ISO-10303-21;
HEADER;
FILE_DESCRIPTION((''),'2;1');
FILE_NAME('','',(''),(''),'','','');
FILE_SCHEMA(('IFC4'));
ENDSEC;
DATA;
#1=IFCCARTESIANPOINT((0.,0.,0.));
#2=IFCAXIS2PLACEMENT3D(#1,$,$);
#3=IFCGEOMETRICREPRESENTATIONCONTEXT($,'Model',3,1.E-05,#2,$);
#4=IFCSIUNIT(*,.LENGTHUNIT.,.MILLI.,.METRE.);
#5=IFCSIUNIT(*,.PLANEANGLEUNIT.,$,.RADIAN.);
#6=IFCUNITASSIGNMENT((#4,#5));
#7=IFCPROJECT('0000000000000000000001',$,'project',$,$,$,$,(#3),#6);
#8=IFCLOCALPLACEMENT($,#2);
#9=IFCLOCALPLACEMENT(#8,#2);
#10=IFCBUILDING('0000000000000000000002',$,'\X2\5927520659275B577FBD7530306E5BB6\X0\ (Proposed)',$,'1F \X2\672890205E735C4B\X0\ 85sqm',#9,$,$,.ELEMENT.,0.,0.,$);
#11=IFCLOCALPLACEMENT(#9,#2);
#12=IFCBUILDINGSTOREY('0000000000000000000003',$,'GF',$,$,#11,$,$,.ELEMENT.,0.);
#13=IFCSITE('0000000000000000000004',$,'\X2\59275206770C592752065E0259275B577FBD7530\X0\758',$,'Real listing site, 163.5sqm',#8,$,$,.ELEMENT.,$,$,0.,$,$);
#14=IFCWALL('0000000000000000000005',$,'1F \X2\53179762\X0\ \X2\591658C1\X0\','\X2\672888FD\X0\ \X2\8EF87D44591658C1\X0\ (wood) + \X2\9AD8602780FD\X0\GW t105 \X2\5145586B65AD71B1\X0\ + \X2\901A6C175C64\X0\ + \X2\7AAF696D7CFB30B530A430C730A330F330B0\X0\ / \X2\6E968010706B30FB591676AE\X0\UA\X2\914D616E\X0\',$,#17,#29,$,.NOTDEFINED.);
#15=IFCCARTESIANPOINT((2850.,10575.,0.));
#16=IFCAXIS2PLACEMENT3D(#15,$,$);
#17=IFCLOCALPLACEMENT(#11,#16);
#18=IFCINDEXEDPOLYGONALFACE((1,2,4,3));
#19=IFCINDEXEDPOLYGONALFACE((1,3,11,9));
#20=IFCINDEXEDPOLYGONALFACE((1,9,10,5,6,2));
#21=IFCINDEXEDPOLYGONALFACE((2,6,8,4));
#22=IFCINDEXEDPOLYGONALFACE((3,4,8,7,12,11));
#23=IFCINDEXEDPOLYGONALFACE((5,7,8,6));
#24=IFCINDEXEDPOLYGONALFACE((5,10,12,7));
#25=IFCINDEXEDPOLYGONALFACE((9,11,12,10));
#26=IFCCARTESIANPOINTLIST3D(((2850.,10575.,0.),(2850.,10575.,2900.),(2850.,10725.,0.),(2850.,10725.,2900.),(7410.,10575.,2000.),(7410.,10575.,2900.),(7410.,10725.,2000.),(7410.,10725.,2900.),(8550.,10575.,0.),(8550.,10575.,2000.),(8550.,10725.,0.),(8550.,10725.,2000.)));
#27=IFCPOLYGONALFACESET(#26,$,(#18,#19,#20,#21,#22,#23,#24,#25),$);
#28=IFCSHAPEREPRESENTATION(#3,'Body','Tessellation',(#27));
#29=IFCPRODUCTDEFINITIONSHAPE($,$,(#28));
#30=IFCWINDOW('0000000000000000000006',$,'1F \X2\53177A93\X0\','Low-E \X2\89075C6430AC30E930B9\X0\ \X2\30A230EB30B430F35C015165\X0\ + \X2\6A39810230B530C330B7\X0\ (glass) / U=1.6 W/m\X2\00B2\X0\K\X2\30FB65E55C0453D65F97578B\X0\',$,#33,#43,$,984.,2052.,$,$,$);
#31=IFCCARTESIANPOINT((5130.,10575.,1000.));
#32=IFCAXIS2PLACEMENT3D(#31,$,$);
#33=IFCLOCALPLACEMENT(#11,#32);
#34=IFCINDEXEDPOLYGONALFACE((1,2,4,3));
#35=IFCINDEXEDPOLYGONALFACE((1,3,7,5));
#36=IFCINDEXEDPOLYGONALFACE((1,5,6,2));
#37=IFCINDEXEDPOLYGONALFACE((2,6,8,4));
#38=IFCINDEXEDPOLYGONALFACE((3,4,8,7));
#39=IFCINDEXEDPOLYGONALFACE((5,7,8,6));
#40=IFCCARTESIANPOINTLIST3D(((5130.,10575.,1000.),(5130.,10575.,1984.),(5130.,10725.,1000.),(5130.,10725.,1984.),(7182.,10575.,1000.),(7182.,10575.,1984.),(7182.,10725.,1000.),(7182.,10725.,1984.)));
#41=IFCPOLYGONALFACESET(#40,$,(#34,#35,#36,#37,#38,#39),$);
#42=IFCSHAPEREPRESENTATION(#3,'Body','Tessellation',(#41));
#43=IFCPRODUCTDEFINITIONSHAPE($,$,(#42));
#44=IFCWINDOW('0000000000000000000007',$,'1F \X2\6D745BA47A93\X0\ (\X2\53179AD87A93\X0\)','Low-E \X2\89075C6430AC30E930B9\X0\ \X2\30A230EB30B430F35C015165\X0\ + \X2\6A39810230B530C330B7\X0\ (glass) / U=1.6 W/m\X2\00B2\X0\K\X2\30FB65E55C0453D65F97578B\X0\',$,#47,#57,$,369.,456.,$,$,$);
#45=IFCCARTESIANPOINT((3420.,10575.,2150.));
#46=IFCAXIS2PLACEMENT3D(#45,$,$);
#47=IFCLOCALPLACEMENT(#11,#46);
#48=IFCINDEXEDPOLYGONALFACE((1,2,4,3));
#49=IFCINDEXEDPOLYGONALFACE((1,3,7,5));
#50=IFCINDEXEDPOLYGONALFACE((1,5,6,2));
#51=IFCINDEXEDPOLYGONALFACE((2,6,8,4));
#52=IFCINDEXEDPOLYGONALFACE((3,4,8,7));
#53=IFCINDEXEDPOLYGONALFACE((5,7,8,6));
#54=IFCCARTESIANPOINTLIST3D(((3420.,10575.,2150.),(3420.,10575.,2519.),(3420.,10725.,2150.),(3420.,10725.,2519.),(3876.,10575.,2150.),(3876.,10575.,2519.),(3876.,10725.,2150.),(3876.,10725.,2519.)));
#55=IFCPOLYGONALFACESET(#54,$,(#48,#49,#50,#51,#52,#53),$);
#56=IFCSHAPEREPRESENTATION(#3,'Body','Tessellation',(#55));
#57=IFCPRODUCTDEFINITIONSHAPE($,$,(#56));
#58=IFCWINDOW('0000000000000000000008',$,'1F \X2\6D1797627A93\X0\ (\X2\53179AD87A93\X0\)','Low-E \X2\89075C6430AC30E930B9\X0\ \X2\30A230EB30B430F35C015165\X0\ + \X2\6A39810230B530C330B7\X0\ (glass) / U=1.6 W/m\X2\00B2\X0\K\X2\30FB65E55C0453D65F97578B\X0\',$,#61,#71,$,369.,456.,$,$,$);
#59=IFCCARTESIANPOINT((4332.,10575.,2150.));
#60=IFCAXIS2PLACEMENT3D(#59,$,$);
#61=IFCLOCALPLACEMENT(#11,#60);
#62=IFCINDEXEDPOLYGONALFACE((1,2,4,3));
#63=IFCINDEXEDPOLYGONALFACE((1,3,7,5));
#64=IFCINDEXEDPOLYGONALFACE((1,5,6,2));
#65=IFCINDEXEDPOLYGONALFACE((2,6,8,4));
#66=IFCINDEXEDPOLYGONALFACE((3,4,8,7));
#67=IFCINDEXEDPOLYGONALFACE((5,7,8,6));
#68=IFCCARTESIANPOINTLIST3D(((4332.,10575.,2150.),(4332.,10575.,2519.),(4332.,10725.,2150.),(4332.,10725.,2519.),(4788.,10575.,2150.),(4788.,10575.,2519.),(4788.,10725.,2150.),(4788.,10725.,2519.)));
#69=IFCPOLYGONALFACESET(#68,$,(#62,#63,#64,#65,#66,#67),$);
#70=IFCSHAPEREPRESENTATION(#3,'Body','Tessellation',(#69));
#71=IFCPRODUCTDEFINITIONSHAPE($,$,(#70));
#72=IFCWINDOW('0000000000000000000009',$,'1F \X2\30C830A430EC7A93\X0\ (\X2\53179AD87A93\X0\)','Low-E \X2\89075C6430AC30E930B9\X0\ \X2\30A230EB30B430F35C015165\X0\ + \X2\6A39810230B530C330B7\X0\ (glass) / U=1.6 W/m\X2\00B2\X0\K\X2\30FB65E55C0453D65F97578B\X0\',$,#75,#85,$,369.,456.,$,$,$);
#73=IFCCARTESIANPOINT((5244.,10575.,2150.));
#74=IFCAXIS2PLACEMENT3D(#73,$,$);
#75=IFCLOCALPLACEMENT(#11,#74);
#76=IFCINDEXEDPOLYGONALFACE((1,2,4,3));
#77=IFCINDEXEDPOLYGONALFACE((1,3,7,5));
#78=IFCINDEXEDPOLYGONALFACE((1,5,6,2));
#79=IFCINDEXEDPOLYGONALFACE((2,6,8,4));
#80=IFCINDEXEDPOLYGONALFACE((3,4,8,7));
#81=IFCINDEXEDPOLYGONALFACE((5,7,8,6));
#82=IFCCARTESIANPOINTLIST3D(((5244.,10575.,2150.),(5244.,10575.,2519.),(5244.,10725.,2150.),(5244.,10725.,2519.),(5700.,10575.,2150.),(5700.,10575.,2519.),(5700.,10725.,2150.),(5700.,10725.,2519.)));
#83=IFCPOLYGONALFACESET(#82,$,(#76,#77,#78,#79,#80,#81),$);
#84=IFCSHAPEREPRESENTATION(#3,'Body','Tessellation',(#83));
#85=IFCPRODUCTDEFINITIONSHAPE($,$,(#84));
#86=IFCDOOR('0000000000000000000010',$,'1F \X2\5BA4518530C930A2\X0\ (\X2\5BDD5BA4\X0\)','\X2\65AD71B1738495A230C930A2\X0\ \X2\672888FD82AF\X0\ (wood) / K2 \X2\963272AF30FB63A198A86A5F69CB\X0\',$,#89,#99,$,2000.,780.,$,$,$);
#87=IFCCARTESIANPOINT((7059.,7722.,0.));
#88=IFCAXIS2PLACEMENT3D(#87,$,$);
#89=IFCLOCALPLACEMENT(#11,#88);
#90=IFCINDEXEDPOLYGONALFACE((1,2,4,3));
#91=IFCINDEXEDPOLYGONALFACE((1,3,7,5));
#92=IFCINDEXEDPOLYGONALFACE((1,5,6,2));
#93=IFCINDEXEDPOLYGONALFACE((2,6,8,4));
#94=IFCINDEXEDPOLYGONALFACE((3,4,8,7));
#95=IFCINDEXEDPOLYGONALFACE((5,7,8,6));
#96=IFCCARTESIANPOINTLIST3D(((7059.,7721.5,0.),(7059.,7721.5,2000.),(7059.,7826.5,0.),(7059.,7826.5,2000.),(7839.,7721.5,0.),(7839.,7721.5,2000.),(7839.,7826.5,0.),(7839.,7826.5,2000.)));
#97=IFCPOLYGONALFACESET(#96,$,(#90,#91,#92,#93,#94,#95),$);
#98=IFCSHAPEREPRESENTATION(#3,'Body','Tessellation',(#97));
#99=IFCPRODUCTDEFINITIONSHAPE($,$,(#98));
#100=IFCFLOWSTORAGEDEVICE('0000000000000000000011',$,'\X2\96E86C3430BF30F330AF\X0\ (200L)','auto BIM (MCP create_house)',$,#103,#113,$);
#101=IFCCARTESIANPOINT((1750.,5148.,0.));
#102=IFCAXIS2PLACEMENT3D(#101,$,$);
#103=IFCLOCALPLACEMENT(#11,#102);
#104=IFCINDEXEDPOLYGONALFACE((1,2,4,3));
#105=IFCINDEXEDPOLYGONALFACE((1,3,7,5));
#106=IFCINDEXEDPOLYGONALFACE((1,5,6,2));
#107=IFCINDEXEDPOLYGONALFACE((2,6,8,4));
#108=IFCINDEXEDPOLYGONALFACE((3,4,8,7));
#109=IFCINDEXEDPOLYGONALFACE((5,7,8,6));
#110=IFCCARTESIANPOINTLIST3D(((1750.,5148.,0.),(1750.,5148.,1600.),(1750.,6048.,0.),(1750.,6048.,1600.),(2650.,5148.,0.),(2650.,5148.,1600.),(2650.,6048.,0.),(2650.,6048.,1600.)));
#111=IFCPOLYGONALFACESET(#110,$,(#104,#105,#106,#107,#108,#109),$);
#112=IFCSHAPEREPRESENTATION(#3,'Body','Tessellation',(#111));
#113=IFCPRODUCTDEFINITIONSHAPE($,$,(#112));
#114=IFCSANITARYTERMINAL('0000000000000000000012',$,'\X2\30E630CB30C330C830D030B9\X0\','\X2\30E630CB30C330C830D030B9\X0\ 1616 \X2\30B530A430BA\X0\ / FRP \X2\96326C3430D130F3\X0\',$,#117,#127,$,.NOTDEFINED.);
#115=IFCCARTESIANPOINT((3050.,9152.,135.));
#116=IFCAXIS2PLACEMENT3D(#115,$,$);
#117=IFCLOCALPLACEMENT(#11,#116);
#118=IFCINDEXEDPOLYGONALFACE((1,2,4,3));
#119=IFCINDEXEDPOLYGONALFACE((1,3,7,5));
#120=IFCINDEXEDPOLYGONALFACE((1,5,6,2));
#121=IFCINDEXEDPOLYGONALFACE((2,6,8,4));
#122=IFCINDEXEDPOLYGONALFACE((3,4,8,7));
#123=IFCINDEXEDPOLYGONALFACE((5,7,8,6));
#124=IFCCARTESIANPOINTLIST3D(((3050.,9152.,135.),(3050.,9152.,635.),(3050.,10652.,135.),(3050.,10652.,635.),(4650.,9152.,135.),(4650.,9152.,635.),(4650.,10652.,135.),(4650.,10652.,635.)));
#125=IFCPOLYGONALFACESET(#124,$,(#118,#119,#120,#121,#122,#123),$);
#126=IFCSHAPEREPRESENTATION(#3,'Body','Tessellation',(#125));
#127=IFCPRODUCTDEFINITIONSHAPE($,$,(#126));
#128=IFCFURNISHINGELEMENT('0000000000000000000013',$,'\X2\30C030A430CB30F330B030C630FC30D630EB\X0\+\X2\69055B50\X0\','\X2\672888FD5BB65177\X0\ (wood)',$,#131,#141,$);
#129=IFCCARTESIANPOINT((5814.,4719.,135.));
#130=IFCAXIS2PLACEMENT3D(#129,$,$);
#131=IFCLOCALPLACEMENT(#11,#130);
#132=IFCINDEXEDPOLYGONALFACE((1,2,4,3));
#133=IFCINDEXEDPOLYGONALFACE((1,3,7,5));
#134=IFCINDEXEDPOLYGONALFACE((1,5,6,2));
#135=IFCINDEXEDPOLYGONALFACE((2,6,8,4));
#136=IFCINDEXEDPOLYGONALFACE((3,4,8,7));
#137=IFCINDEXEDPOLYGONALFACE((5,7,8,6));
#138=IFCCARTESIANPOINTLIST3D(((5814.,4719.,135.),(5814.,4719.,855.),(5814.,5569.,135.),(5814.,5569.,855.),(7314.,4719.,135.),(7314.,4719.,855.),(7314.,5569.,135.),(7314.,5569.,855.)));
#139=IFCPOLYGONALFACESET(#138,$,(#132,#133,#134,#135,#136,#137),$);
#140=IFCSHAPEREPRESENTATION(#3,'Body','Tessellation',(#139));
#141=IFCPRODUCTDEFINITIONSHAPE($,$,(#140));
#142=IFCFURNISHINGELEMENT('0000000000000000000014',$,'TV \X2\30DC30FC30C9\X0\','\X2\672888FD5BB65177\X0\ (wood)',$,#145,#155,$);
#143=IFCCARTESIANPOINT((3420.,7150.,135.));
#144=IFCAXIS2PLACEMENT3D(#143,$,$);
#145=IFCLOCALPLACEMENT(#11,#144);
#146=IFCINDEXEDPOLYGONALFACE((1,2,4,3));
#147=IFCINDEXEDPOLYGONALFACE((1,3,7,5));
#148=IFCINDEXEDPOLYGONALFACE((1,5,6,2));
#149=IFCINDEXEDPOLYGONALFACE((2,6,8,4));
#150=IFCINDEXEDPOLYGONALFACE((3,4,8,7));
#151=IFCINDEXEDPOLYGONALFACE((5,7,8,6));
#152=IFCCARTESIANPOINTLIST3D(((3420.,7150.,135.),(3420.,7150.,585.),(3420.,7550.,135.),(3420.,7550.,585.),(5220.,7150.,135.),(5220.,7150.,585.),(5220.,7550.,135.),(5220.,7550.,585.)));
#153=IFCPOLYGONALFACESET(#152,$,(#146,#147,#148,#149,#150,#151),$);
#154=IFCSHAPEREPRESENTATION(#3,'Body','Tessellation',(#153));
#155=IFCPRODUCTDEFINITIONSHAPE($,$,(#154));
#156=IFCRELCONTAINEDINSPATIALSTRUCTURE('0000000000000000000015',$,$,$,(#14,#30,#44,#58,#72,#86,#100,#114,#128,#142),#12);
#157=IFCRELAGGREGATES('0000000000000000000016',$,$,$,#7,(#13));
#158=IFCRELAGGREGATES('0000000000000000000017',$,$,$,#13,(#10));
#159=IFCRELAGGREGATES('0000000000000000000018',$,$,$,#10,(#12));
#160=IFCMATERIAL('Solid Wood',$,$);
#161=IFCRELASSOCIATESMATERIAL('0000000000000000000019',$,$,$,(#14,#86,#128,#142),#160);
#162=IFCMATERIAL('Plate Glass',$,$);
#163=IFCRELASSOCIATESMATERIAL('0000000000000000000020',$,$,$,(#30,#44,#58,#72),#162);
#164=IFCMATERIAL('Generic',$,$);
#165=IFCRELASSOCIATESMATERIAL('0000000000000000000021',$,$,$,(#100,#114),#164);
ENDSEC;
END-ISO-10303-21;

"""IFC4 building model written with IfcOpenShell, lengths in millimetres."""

from ifc_helpers import new_model, si_unit, frame, frame_2d, origin, place, context, project, spatial, rectangle, extrude, material, element, fill, save


model = new_model("IFC4")

# Units and contexts
model_context = context("Model", 3, precision=1e-05, world=origin())
ifc_project = project(units=[si_unit("LENGTHUNIT", "METRE", prefix="MILLI"), si_unit("PLANEANGLEUNIT", "RADIAN")], contexts=[model_context])

# Site, building, storey
site_placement = place(None, origin())
site = spatial("IfcSite", under=ifc_project, at=site_placement, Name="大分県大分市大字羽田758", ObjectType="Real listing site, 163.5sqm", CompositionType="ELEMENT", RefElevation=0.0)
building_placement = place(site_placement, origin())
building = spatial("IfcBuilding", under=site, at=building_placement, Name="大分大字羽田の家 (Proposed)", ObjectType="1F 木造平屋 85sqm", CompositionType="ELEMENT", ElevationOfRefHeight=0.0, ElevationOfTerrain=0.0)
storey_placement = place(building_placement, origin())
storey = spatial("IfcBuildingStorey", under=building, at=storey_placement, Name="GF", CompositionType="ELEMENT", Elevation=0.0)

# Wall, openings, windows
ifc_material_1 = material(Name="Solid Wood")
wall_1_placement = place(storey_placement, frame((2850.0, 10575.0, 0.0)))
wall_1 = element("IfcWall", 1, at=wall_1_placement, inside=storey, material=ifc_material_1, Name="1F 北面 外壁", Description="木製 軸組外壁 (wood) + 高性能GW t105 充填断熱 + 通気層 + 窯業系サイディング / 準耐火・外皮UA配慮", PredefinedType="NOTDEFINED", context=model_context, shape_type="SweptSolid", body=[
    extrude(rectangle(XDim=5700.0, YDim=150.0, at=frame_2d((2850.0, 75.0))), frame((2850.0, 10575.0, 0.0)), (0.0, 0.0, 1.0), 2900.0),
])
opening_1_placement = place(storey_placement, frame((5130.0, 10575.0, 1000.0)))
opening_1 = element("IfcOpeningElement", 2, at=opening_1_placement, cuts=wall_1, PredefinedType="NOTDEFINED", context=model_context, shape_type="SweptSolid", body=[
    extrude(rectangle(XDim=2052.0, YDim=150.0, at=frame_2d((1026.0, 75.0))), frame((5130.0, 10575.0, 1000.0)), (0.0, 0.0, 1.0), 984.0),
])
opening_2_placement = place(storey_placement, frame((3420.0, 10575.0, 2150.0)))
opening_2 = element("IfcOpeningElement", 3, at=opening_2_placement, cuts=wall_1, PredefinedType="NOTDEFINED", context=model_context, shape_type="SweptSolid", body=[
    extrude(rectangle(XDim=456.0, YDim=150.0, at=frame_2d((228.0, 75.0))), frame((3420.0, 10575.0, 2150.0)), (0.0, 0.0, 1.0), 369.0),
])
opening_3_placement = place(storey_placement, frame((4332.0, 10575.0, 2150.0)))
opening_3 = element("IfcOpeningElement", 4, at=opening_3_placement, cuts=wall_1, PredefinedType="NOTDEFINED", context=model_context, shape_type="SweptSolid", body=[
    extrude(rectangle(XDim=456.0, YDim=150.0, at=frame_2d((228.0, 75.0))), frame((4332.0, 10575.0, 2150.0)), (0.0, 0.0, 1.0), 369.0),
])
opening_4_placement = place(storey_placement, frame((5244.0, 10575.0, 2150.0)))
opening_4 = element("IfcOpeningElement", 5, at=opening_4_placement, cuts=wall_1, PredefinedType="NOTDEFINED", context=model_context, shape_type="SweptSolid", body=[
    extrude(rectangle(XDim=456.0, YDim=150.0, at=frame_2d((228.0, 75.0))), frame((5244.0, 10575.0, 2150.0)), (0.0, 0.0, 1.0), 369.0),
])
ifc_material_2 = material(Name="Plate Glass")
window_1_placement = place(storey_placement, frame((5130.0, 10575.0, 1000.0)))
window_1 = element("IfcWindow", 6, at=window_1_placement, inside=storey, material=ifc_material_2, Name="1F 北窓", Description="Low-E 複層ガラス アルゴン封入 + 樹脂サッシ (glass) / U=1.6 W/m²K・日射取得型", OverallHeight=984.0, OverallWidth=2052.0, context=model_context, shape_type="SweptSolid", body=[
    extrude(rectangle(XDim=2052.0, YDim=150.0, at=frame_2d((1026.0, 75.0))), frame((5130.0, 10575.0, 1000.0)), (0.0, 0.0, 1.0), 984.0),
])
fill(opening_1, window_1)
window_2_placement = place(storey_placement, frame((3420.0, 10575.0, 2150.0)))
window_2 = element("IfcWindow", 7, at=window_2_placement, inside=storey, material=ifc_material_2, Name="1F 浴室窓 (北高窓)", Description="Low-E 複層ガラス アルゴン封入 + 樹脂サッシ (glass) / U=1.6 W/m²K・日射取得型", OverallHeight=369.0, OverallWidth=456.0, context=model_context, shape_type="SweptSolid", body=[
    extrude(rectangle(XDim=456.0, YDim=150.0, at=frame_2d((228.0, 75.0))), frame((3420.0, 10575.0, 2150.0)), (0.0, 0.0, 1.0), 369.0),
])
fill(opening_2, window_2)
window_3_placement = place(storey_placement, frame((4332.0, 10575.0, 2150.0)))
window_3 = element("IfcWindow", 8, at=window_3_placement, inside=storey, material=ifc_material_2, Name="1F 洗面窓 (北高窓)", Description="Low-E 複層ガラス アルゴン封入 + 樹脂サッシ (glass) / U=1.6 W/m²K・日射取得型", OverallHeight=369.0, OverallWidth=456.0, context=model_context, shape_type="SweptSolid", body=[
    extrude(rectangle(XDim=456.0, YDim=150.0, at=frame_2d((228.0, 75.0))), frame((4332.0, 10575.0, 2150.0)), (0.0, 0.0, 1.0), 369.0),
])
fill(opening_3, window_3)
window_4_placement = place(storey_placement, frame((5244.0, 10575.0, 2150.0)))
window_4 = element("IfcWindow", 9, at=window_4_placement, inside=storey, material=ifc_material_2, Name="1F トイレ窓 (北高窓)", Description="Low-E 複層ガラス アルゴン封入 + 樹脂サッシ (glass) / U=1.6 W/m²K・日射取得型", OverallHeight=369.0, OverallWidth=456.0, context=model_context, shape_type="SweptSolid", body=[
    extrude(rectangle(XDim=456.0, YDim=150.0, at=frame_2d((228.0, 75.0))), frame((5244.0, 10575.0, 2150.0)), (0.0, 0.0, 1.0), 369.0),
])
fill(opening_4, window_4)

# Door
door_1_placement = place(storey_placement, frame((7059.0, 7722.0, 0.0)))
element("IfcDoor", 10, at=door_1_placement, inside=storey, material=ifc_material_1, Name="1F 室内ドア (寝室)", Description="断熱玄関ドア 木製芯 (wood) / K2 防犯・採風機構", OverallHeight=2000.0, OverallWidth=780.0, context=model_context, shape_type="SweptSolid", body=[
    extrude(rectangle(XDim=780.0, YDim=105.0, at=frame_2d((390.0, 52.0))), frame((7059.0, 7722.0, 0.0)), (0.0, 0.0, 1.0), 2000.0),
])

# Flow storage device
ifc_material_3 = material(Name="Generic")
flow_storage_device_placement = place(storey_placement, frame((1750.0, 5148.0, 0.0)))
element("IfcFlowStorageDevice", 11, at=flow_storage_device_placement, inside=storey, material=ifc_material_3, Name="雨水タンク (200L)", Description="auto BIM (MCP create_house)", context=model_context, shape_type="SweptSolid", body=[
    extrude(rectangle(XDim=900.0, YDim=900.0, at=frame_2d((450.0, 450.0))), frame((1750.0, 5148.0, 0.0)), (0.0, 0.0, 1.0), 1600.0),
])

# Sanitary terminal
sanitary_terminal_placement = place(storey_placement, frame((3050.0, 9152.0, 135.0)))
element("IfcSanitaryTerminal", 12, at=sanitary_terminal_placement, inside=storey, material=ifc_material_3, Name="ユニットバス", Description="ユニットバス 1616 サイズ / FRP 防水パン", PredefinedType="NOTDEFINED", context=model_context, shape_type="SweptSolid", body=[
    extrude(rectangle(XDim=1600.0, YDim=1500.0, at=frame_2d((800.0, 750.0))), frame((3050.0, 9152.0, 135.0)), (0.0, 0.0, 1.0), 500.0),
])

# Furnishing elements
furnishing_1_placement = place(storey_placement, frame((5814.0, 4719.0, 135.0)))
element("IfcFurnishingElement", 13, at=furnishing_1_placement, inside=storey, material=ifc_material_1, Name="ダイニングテーブル+椅子", Description="木製家具 (wood)", context=model_context, shape_type="SweptSolid", body=[
    extrude(rectangle(XDim=1500.0, YDim=850.0, at=frame_2d((750.0, 425.0))), frame((5814.0, 4719.0, 135.0)), (0.0, 0.0, 1.0), 720.0),
])
furnishing_2_placement = place(storey_placement, frame((3420.0, 7150.0, 135.0)))
element("IfcFurnishingElement", 14, at=furnishing_2_placement, inside=storey, material=ifc_material_1, Name="TV ボード", Description="木製家具 (wood)", context=model_context, shape_type="SweptSolid", body=[
    extrude(rectangle(XDim=1800.0, YDim=400.0, at=frame_2d((900.0, 200.0))), frame((3420.0, 7150.0, 135.0)), (0.0, 0.0, 1.0), 450.0),
])

save(model, "model.ifc")
